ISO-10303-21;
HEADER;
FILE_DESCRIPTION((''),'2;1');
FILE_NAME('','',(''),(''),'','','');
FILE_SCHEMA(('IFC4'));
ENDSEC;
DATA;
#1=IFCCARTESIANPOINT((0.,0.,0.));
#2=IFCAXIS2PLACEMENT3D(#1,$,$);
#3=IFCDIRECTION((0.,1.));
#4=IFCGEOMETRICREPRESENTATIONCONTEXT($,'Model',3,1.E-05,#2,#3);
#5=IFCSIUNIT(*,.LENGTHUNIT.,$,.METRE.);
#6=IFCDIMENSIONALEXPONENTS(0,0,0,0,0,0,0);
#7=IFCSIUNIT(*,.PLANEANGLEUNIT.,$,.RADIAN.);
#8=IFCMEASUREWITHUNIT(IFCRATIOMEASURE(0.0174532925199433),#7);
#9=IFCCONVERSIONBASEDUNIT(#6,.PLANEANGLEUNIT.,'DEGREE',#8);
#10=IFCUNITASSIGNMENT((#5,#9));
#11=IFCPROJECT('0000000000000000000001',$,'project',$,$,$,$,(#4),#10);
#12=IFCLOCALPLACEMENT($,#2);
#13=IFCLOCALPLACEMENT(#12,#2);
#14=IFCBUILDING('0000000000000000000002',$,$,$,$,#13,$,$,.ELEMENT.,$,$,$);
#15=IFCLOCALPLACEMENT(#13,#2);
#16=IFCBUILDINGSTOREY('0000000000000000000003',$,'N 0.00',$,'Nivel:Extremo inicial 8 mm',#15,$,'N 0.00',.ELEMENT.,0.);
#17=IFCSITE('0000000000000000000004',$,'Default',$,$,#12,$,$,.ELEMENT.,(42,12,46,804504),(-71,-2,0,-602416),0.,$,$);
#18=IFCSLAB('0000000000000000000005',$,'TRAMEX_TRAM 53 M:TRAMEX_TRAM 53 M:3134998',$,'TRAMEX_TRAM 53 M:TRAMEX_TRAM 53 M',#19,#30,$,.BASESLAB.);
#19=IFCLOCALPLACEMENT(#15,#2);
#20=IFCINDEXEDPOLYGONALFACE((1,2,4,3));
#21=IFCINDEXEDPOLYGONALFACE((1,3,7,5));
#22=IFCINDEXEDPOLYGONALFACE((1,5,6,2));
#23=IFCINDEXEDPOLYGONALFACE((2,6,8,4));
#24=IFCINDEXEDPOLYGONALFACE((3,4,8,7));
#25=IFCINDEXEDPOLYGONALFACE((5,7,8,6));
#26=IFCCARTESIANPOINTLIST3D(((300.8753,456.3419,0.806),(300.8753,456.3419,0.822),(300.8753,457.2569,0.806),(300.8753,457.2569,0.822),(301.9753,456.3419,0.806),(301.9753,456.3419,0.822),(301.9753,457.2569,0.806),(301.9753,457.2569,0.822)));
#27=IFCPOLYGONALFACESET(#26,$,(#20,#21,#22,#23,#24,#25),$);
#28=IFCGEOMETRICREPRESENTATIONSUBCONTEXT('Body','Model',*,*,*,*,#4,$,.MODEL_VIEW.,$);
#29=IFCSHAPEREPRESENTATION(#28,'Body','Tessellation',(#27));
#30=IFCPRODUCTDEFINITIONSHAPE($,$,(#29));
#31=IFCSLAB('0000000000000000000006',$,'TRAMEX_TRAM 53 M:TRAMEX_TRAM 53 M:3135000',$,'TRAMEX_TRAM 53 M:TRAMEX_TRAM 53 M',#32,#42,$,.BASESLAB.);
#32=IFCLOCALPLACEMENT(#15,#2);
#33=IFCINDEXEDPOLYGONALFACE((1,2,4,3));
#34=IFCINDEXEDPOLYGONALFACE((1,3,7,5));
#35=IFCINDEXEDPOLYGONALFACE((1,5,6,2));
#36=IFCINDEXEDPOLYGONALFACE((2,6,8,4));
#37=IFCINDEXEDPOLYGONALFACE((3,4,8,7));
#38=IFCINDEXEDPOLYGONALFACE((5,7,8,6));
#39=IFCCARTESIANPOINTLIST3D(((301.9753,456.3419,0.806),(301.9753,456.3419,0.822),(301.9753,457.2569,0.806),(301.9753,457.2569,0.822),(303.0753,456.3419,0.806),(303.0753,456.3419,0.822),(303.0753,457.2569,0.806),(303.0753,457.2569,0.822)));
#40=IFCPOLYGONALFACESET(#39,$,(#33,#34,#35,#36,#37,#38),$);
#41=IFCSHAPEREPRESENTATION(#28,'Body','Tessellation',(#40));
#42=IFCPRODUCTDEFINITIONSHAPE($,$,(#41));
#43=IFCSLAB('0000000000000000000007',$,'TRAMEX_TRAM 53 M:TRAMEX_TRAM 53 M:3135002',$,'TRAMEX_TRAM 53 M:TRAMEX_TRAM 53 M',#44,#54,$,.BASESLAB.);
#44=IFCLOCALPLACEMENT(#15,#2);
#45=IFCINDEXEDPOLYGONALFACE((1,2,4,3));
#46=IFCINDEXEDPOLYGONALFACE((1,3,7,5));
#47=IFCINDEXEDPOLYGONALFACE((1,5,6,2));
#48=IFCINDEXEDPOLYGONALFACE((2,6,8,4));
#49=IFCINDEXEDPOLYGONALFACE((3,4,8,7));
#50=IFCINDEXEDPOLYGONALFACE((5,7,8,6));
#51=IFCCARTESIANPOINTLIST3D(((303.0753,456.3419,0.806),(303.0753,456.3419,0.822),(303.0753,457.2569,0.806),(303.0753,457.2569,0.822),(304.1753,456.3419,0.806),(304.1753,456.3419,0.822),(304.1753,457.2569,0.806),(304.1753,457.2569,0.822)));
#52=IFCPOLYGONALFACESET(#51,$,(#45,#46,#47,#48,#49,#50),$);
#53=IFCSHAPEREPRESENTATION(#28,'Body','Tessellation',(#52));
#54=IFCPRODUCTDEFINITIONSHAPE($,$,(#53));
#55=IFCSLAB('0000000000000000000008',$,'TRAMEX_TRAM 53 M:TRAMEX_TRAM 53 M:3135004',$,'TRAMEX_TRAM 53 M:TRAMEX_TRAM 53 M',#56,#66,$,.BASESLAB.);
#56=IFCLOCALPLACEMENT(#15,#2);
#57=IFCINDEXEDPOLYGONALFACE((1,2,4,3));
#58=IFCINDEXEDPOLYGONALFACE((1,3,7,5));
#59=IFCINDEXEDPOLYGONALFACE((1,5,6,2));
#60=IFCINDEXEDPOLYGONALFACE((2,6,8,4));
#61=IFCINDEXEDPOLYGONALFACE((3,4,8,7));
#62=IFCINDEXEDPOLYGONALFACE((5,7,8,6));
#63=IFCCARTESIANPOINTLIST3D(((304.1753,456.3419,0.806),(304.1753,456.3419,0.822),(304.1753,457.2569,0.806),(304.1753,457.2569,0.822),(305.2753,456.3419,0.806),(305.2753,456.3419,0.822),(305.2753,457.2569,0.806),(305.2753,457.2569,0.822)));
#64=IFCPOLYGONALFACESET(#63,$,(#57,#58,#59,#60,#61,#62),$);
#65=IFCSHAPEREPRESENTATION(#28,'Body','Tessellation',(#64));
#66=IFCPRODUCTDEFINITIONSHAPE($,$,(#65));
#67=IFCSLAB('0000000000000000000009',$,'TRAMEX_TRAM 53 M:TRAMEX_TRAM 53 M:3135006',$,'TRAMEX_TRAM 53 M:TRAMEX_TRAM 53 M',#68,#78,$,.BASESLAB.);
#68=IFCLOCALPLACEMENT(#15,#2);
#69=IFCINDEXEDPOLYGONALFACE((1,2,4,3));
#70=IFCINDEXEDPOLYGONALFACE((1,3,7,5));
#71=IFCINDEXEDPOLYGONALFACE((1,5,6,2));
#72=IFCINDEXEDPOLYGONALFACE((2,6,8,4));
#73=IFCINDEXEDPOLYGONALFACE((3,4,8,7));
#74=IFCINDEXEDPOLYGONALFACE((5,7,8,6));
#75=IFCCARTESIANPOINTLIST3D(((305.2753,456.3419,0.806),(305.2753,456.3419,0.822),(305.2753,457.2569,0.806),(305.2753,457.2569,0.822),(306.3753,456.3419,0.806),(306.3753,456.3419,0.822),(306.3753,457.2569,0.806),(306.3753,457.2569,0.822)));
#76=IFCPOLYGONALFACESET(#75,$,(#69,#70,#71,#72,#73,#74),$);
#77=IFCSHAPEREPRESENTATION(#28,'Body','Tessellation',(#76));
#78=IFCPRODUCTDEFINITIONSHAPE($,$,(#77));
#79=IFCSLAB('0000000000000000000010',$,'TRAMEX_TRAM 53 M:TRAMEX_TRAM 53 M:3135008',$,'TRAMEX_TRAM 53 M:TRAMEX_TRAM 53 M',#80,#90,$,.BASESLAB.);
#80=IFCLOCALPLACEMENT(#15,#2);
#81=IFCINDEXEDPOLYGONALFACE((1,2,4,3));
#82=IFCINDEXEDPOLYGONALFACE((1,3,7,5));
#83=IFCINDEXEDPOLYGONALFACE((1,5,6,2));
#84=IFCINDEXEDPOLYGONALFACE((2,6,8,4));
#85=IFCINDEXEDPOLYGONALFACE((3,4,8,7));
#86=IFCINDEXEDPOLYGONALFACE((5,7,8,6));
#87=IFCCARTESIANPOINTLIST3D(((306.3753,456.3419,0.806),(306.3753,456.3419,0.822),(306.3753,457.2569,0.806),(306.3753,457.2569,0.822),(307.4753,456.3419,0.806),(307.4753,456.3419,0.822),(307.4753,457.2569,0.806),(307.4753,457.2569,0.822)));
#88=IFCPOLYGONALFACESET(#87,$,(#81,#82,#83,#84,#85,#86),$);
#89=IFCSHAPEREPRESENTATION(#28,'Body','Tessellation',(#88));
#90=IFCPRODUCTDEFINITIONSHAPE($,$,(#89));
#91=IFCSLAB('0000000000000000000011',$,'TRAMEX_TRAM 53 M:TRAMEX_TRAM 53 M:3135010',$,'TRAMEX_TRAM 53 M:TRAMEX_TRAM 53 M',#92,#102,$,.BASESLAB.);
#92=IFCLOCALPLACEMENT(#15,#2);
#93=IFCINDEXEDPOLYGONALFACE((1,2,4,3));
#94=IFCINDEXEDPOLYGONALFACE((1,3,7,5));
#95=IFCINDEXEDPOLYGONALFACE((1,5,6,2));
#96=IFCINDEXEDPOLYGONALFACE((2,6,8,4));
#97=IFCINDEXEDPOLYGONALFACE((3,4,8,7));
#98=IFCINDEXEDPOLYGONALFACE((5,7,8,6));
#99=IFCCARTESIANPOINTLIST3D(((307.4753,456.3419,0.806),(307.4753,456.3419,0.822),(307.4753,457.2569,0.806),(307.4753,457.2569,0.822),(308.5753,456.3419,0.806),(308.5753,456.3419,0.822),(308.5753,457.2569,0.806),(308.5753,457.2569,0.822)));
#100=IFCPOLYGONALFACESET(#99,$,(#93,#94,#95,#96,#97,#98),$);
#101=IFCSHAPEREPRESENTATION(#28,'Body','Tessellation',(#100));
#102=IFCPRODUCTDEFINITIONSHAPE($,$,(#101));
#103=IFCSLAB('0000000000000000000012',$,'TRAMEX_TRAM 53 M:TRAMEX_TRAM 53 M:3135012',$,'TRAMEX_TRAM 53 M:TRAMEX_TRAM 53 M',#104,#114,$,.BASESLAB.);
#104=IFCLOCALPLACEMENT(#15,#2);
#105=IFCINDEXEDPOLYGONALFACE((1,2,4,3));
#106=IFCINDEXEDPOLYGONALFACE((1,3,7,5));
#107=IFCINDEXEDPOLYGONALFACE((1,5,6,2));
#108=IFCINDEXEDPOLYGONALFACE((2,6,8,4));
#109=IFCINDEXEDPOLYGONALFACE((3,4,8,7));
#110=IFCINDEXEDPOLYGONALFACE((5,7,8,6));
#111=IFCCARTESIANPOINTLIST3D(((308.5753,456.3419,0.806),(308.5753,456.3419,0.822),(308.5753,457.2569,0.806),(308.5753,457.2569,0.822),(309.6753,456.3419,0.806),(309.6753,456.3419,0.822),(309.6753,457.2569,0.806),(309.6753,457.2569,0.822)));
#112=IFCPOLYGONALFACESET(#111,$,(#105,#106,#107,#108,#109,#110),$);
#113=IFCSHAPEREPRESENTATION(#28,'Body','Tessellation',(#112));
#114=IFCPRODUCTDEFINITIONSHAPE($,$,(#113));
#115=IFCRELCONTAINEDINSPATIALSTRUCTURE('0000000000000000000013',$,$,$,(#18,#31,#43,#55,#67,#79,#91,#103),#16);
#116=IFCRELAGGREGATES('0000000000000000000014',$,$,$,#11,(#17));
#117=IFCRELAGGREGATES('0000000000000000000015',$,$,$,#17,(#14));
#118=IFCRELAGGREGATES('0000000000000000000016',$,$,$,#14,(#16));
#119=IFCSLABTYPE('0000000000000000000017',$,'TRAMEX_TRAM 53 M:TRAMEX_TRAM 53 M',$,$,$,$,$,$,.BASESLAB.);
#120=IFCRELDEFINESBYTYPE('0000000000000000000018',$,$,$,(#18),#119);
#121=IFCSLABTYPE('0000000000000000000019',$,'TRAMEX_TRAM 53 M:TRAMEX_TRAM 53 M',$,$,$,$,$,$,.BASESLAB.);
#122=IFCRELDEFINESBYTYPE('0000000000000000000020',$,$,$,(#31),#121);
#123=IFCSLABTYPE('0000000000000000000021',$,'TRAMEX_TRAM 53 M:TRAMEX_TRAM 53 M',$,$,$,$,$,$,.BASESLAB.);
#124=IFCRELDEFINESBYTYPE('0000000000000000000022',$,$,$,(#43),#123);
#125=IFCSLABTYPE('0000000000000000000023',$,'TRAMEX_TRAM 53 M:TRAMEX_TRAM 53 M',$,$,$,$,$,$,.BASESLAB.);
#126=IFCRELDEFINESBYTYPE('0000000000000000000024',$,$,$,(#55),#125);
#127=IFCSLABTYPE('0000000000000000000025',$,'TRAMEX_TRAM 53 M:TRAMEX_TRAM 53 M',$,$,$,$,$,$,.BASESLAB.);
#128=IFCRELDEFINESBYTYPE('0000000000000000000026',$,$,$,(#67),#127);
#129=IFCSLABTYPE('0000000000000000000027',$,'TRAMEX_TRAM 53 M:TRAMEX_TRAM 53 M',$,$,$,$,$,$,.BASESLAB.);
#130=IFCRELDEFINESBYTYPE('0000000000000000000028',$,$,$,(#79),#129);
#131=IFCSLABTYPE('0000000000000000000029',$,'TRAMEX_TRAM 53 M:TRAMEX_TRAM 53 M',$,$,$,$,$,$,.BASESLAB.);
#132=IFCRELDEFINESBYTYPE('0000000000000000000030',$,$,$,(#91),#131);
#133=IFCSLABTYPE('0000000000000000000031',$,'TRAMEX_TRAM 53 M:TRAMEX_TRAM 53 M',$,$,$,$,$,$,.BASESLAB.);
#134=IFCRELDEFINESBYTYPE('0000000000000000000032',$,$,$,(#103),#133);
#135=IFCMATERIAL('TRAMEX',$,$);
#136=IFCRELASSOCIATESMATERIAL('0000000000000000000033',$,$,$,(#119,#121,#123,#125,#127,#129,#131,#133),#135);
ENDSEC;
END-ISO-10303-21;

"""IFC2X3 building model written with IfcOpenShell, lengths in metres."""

from ifc_helpers import new_model, entity, si_unit, converted_unit, direction, frame, frame_2d, origin, place, context, subcontext, project, spatial, rectangle, extrude, material, type_object, element, save


model = new_model("IFC2X3")

# Units and contexts
model_context = context("Model", 3, precision=1e-05, world=origin(), true_north=direction((0.0, 1.0)))
body_context = subcontext(model_context, "Body", "Model", "MODEL_VIEW")
ifc_project = project(units=[si_unit("LENGTHUNIT", "METRE"), converted_unit("PLANEANGLEUNIT", "DEGREE", entity("IfcRatioMeasure", 0.0174532925199433), si_unit("PLANEANGLEUNIT", "RADIAN"), dimensions=[0, 0, 0, 0, 0, 0, 0])], contexts=[model_context])

# Site, building, storey
site_placement = place(None, origin())
site = spatial("IfcSite", under=ifc_project, at=site_placement, Name="Default", CompositionType="ELEMENT", RefLatitude=(42, 12, 46, 804504), RefLongitude=(-71, -2, 0, -602416), RefElevation=0.0)
building_placement = place(site_placement, origin())
building = spatial("IfcBuilding", under=site, at=building_placement, CompositionType="ELEMENT")
storey_placement = place(building_placement, origin())
storey = spatial("IfcBuildingStorey", under=building, at=storey_placement, Name="N 0.00", ObjectType="Nivel:Extremo inicial 8 mm", LongName="N 0.00", CompositionType="ELEMENT", Elevation=0.0)

# Slabs
ifc_material = material(Name="TRAMEX")
slab_type_1 = type_object("IfcSlabType", Name="TRAMEX_TRAM 53 M:TRAMEX_TRAM 53 M", PredefinedType="BASESLAB", material=ifc_material)
slab_1_placement = place(storey_placement, origin())
element("IfcSlab", 1, at=slab_1_placement, inside=storey, type_object=slab_type_1, Name="TRAMEX_TRAM 53 M:TRAMEX_TRAM 53 M:3134998", ObjectType="TRAMEX_TRAM 53 M:TRAMEX_TRAM 53 M", PredefinedType="BASESLAB", context=body_context, shape_type="SweptSolid", body=[
    extrude(rectangle(XDim=1.1, YDim=0.915, at=frame_2d((0.0, 0.0), x_axis=(1.0, 0.0))), frame((301.4253, 456.7994, 0.806), z_axis=(0.0, 0.0, 1.0), x_axis=(-1.0, 0.0, 0.0)), (0.0, 0.0, 1.0), 0.016),
])
slab_type_2 = type_object("IfcSlabType", Name="TRAMEX_TRAM 53 M:TRAMEX_TRAM 53 M", PredefinedType="BASESLAB", material=ifc_material)
slab_2_placement = place(storey_placement, origin())
element("IfcSlab", 2, at=slab_2_placement, inside=storey, type_object=slab_type_2, Name="TRAMEX_TRAM 53 M:TRAMEX_TRAM 53 M:3135000", ObjectType="TRAMEX_TRAM 53 M:TRAMEX_TRAM 53 M", PredefinedType="BASESLAB", context=body_context, shape_type="SweptSolid", body=[
    extrude(rectangle(XDim=1.1, YDim=0.915, at=frame_2d((0.0, 0.0), x_axis=(1.0, 0.0))), frame((302.5253, 456.7994, 0.806), z_axis=(0.0, 0.0, 1.0), x_axis=(-1.0, 0.0, 0.0)), (0.0, 0.0, 1.0), 0.016),
])
slab_type_3 = type_object("IfcSlabType", Name="TRAMEX_TRAM 53 M:TRAMEX_TRAM 53 M", PredefinedType="BASESLAB", material=ifc_material)
slab_3_placement = place(storey_placement, origin())
element("IfcSlab", 3, at=slab_3_placement, inside=storey, type_object=slab_type_3, Name="TRAMEX_TRAM 53 M:TRAMEX_TRAM 53 M:3135002", ObjectType="TRAMEX_TRAM 53 M:TRAMEX_TRAM 53 M", PredefinedType="BASESLAB", context=body_context, shape_type="SweptSolid", body=[
    extrude(rectangle(XDim=1.1, YDim=0.915, at=frame_2d((0.0, 0.0), x_axis=(1.0, 0.0))), frame((303.6253, 456.7994, 0.806), z_axis=(0.0, 0.0, 1.0), x_axis=(-1.0, 0.0, 0.0)), (0.0, 0.0, 1.0), 0.016),
])
slab_type_4 = type_object("IfcSlabType", Name="TRAMEX_TRAM 53 M:TRAMEX_TRAM 53 M", PredefinedType="BASESLAB", material=ifc_material)
slab_4_placement = place(storey_placement, origin())
element("IfcSlab", 4, at=slab_4_placement, inside=storey, type_object=slab_type_4, Name="TRAMEX_TRAM 53 M:TRAMEX_TRAM 53 M:3135004", ObjectType="TRAMEX_TRAM 53 M:TRAMEX_TRAM 53 M", PredefinedType="BASESLAB", context=body_context, shape_type="SweptSolid", body=[
    extrude(rectangle(XDim=1.1, YDim=0.915, at=frame_2d((0.0, 0.0), x_axis=(1.0, 0.0))), frame((304.7253, 456.7994, 0.806), z_axis=(0.0, 0.0, 1.0), x_axis=(-1.0, 0.0, 0.0)), (0.0, 0.0, 1.0), 0.016),
])
slab_type_5 = type_object("IfcSlabType", Name="TRAMEX_TRAM 53 M:TRAMEX_TRAM 53 M", PredefinedType="BASESLAB", material=ifc_material)
slab_5_placement = place(storey_placement, origin())
element("IfcSlab", 5, at=slab_5_placement, inside=storey, type_object=slab_type_5, Name="TRAMEX_TRAM 53 M:TRAMEX_TRAM 53 M:3135006", ObjectType="TRAMEX_TRAM 53 M:TRAMEX_TRAM 53 M", PredefinedType="BASESLAB", context=body_context, shape_type="SweptSolid", body=[
    extrude(rectangle(XDim=1.1, YDim=0.915, at=frame_2d((0.0, 0.0), x_axis=(1.0, 0.0))), frame((305.8253, 456.7994, 0.806), z_axis=(0.0, 0.0, 1.0), x_axis=(-1.0, 0.0, 0.0)), (0.0, 0.0, 1.0), 0.016),
])
slab_type_6 = type_object("IfcSlabType", Name="TRAMEX_TRAM 53 M:TRAMEX_TRAM 53 M", PredefinedType="BASESLAB", material=ifc_material)
slab_6_placement = place(storey_placement, origin())
element("IfcSlab", 6, at=slab_6_placement, inside=storey, type_object=slab_type_6, Name="TRAMEX_TRAM 53 M:TRAMEX_TRAM 53 M:3135008", ObjectType="TRAMEX_TRAM 53 M:TRAMEX_TRAM 53 M", PredefinedType="BASESLAB", context=body_context, shape_type="SweptSolid", body=[
    extrude(rectangle(XDim=1.1, YDim=0.915, at=frame_2d((0.0, 0.0), x_axis=(1.0, 0.0))), frame((306.9253, 456.7994, 0.806), z_axis=(0.0, 0.0, 1.0), x_axis=(-1.0, 0.0, 0.0)), (0.0, 0.0, 1.0), 0.016),
])
slab_type_7 = type_object("IfcSlabType", Name="TRAMEX_TRAM 53 M:TRAMEX_TRAM 53 M", PredefinedType="BASESLAB", material=ifc_material)
slab_7_placement = place(storey_placement, origin())
element("IfcSlab", 7, at=slab_7_placement, inside=storey, type_object=slab_type_7, Name="TRAMEX_TRAM 53 M:TRAMEX_TRAM 53 M:3135010", ObjectType="TRAMEX_TRAM 53 M:TRAMEX_TRAM 53 M", PredefinedType="BASESLAB", context=body_context, shape_type="SweptSolid", body=[
    extrude(rectangle(XDim=1.1, YDim=0.915, at=frame_2d((0.0, 0.0), x_axis=(1.0, 0.0))), frame((308.0253, 456.7994, 0.806), z_axis=(0.0, 0.0, 1.0), x_axis=(-1.0, 0.0, 0.0)), (0.0, 0.0, 1.0), 0.016),
])
slab_type_8 = type_object("IfcSlabType", Name="TRAMEX_TRAM 53 M:TRAMEX_TRAM 53 M", PredefinedType="BASESLAB", material=ifc_material)
slab_8_placement = place(storey_placement, origin())
element("IfcSlab", 8, at=slab_8_placement, inside=storey, type_object=slab_type_8, Name="TRAMEX_TRAM 53 M:TRAMEX_TRAM 53 M:3135012", ObjectType="TRAMEX_TRAM 53 M:TRAMEX_TRAM 53 M", PredefinedType="BASESLAB", context=body_context, shape_type="SweptSolid", body=[
    extrude(rectangle(XDim=1.1, YDim=0.915, at=frame_2d((0.0, 0.0), x_axis=(1.0, 0.0))), frame((309.1253, 456.7994, 0.806), z_axis=(0.0, 0.0, 1.0), x_axis=(-1.0, 0.0, 0.0)), (0.0, 0.0, 1.0), 0.016),
])

save(model, "model.ifc")
